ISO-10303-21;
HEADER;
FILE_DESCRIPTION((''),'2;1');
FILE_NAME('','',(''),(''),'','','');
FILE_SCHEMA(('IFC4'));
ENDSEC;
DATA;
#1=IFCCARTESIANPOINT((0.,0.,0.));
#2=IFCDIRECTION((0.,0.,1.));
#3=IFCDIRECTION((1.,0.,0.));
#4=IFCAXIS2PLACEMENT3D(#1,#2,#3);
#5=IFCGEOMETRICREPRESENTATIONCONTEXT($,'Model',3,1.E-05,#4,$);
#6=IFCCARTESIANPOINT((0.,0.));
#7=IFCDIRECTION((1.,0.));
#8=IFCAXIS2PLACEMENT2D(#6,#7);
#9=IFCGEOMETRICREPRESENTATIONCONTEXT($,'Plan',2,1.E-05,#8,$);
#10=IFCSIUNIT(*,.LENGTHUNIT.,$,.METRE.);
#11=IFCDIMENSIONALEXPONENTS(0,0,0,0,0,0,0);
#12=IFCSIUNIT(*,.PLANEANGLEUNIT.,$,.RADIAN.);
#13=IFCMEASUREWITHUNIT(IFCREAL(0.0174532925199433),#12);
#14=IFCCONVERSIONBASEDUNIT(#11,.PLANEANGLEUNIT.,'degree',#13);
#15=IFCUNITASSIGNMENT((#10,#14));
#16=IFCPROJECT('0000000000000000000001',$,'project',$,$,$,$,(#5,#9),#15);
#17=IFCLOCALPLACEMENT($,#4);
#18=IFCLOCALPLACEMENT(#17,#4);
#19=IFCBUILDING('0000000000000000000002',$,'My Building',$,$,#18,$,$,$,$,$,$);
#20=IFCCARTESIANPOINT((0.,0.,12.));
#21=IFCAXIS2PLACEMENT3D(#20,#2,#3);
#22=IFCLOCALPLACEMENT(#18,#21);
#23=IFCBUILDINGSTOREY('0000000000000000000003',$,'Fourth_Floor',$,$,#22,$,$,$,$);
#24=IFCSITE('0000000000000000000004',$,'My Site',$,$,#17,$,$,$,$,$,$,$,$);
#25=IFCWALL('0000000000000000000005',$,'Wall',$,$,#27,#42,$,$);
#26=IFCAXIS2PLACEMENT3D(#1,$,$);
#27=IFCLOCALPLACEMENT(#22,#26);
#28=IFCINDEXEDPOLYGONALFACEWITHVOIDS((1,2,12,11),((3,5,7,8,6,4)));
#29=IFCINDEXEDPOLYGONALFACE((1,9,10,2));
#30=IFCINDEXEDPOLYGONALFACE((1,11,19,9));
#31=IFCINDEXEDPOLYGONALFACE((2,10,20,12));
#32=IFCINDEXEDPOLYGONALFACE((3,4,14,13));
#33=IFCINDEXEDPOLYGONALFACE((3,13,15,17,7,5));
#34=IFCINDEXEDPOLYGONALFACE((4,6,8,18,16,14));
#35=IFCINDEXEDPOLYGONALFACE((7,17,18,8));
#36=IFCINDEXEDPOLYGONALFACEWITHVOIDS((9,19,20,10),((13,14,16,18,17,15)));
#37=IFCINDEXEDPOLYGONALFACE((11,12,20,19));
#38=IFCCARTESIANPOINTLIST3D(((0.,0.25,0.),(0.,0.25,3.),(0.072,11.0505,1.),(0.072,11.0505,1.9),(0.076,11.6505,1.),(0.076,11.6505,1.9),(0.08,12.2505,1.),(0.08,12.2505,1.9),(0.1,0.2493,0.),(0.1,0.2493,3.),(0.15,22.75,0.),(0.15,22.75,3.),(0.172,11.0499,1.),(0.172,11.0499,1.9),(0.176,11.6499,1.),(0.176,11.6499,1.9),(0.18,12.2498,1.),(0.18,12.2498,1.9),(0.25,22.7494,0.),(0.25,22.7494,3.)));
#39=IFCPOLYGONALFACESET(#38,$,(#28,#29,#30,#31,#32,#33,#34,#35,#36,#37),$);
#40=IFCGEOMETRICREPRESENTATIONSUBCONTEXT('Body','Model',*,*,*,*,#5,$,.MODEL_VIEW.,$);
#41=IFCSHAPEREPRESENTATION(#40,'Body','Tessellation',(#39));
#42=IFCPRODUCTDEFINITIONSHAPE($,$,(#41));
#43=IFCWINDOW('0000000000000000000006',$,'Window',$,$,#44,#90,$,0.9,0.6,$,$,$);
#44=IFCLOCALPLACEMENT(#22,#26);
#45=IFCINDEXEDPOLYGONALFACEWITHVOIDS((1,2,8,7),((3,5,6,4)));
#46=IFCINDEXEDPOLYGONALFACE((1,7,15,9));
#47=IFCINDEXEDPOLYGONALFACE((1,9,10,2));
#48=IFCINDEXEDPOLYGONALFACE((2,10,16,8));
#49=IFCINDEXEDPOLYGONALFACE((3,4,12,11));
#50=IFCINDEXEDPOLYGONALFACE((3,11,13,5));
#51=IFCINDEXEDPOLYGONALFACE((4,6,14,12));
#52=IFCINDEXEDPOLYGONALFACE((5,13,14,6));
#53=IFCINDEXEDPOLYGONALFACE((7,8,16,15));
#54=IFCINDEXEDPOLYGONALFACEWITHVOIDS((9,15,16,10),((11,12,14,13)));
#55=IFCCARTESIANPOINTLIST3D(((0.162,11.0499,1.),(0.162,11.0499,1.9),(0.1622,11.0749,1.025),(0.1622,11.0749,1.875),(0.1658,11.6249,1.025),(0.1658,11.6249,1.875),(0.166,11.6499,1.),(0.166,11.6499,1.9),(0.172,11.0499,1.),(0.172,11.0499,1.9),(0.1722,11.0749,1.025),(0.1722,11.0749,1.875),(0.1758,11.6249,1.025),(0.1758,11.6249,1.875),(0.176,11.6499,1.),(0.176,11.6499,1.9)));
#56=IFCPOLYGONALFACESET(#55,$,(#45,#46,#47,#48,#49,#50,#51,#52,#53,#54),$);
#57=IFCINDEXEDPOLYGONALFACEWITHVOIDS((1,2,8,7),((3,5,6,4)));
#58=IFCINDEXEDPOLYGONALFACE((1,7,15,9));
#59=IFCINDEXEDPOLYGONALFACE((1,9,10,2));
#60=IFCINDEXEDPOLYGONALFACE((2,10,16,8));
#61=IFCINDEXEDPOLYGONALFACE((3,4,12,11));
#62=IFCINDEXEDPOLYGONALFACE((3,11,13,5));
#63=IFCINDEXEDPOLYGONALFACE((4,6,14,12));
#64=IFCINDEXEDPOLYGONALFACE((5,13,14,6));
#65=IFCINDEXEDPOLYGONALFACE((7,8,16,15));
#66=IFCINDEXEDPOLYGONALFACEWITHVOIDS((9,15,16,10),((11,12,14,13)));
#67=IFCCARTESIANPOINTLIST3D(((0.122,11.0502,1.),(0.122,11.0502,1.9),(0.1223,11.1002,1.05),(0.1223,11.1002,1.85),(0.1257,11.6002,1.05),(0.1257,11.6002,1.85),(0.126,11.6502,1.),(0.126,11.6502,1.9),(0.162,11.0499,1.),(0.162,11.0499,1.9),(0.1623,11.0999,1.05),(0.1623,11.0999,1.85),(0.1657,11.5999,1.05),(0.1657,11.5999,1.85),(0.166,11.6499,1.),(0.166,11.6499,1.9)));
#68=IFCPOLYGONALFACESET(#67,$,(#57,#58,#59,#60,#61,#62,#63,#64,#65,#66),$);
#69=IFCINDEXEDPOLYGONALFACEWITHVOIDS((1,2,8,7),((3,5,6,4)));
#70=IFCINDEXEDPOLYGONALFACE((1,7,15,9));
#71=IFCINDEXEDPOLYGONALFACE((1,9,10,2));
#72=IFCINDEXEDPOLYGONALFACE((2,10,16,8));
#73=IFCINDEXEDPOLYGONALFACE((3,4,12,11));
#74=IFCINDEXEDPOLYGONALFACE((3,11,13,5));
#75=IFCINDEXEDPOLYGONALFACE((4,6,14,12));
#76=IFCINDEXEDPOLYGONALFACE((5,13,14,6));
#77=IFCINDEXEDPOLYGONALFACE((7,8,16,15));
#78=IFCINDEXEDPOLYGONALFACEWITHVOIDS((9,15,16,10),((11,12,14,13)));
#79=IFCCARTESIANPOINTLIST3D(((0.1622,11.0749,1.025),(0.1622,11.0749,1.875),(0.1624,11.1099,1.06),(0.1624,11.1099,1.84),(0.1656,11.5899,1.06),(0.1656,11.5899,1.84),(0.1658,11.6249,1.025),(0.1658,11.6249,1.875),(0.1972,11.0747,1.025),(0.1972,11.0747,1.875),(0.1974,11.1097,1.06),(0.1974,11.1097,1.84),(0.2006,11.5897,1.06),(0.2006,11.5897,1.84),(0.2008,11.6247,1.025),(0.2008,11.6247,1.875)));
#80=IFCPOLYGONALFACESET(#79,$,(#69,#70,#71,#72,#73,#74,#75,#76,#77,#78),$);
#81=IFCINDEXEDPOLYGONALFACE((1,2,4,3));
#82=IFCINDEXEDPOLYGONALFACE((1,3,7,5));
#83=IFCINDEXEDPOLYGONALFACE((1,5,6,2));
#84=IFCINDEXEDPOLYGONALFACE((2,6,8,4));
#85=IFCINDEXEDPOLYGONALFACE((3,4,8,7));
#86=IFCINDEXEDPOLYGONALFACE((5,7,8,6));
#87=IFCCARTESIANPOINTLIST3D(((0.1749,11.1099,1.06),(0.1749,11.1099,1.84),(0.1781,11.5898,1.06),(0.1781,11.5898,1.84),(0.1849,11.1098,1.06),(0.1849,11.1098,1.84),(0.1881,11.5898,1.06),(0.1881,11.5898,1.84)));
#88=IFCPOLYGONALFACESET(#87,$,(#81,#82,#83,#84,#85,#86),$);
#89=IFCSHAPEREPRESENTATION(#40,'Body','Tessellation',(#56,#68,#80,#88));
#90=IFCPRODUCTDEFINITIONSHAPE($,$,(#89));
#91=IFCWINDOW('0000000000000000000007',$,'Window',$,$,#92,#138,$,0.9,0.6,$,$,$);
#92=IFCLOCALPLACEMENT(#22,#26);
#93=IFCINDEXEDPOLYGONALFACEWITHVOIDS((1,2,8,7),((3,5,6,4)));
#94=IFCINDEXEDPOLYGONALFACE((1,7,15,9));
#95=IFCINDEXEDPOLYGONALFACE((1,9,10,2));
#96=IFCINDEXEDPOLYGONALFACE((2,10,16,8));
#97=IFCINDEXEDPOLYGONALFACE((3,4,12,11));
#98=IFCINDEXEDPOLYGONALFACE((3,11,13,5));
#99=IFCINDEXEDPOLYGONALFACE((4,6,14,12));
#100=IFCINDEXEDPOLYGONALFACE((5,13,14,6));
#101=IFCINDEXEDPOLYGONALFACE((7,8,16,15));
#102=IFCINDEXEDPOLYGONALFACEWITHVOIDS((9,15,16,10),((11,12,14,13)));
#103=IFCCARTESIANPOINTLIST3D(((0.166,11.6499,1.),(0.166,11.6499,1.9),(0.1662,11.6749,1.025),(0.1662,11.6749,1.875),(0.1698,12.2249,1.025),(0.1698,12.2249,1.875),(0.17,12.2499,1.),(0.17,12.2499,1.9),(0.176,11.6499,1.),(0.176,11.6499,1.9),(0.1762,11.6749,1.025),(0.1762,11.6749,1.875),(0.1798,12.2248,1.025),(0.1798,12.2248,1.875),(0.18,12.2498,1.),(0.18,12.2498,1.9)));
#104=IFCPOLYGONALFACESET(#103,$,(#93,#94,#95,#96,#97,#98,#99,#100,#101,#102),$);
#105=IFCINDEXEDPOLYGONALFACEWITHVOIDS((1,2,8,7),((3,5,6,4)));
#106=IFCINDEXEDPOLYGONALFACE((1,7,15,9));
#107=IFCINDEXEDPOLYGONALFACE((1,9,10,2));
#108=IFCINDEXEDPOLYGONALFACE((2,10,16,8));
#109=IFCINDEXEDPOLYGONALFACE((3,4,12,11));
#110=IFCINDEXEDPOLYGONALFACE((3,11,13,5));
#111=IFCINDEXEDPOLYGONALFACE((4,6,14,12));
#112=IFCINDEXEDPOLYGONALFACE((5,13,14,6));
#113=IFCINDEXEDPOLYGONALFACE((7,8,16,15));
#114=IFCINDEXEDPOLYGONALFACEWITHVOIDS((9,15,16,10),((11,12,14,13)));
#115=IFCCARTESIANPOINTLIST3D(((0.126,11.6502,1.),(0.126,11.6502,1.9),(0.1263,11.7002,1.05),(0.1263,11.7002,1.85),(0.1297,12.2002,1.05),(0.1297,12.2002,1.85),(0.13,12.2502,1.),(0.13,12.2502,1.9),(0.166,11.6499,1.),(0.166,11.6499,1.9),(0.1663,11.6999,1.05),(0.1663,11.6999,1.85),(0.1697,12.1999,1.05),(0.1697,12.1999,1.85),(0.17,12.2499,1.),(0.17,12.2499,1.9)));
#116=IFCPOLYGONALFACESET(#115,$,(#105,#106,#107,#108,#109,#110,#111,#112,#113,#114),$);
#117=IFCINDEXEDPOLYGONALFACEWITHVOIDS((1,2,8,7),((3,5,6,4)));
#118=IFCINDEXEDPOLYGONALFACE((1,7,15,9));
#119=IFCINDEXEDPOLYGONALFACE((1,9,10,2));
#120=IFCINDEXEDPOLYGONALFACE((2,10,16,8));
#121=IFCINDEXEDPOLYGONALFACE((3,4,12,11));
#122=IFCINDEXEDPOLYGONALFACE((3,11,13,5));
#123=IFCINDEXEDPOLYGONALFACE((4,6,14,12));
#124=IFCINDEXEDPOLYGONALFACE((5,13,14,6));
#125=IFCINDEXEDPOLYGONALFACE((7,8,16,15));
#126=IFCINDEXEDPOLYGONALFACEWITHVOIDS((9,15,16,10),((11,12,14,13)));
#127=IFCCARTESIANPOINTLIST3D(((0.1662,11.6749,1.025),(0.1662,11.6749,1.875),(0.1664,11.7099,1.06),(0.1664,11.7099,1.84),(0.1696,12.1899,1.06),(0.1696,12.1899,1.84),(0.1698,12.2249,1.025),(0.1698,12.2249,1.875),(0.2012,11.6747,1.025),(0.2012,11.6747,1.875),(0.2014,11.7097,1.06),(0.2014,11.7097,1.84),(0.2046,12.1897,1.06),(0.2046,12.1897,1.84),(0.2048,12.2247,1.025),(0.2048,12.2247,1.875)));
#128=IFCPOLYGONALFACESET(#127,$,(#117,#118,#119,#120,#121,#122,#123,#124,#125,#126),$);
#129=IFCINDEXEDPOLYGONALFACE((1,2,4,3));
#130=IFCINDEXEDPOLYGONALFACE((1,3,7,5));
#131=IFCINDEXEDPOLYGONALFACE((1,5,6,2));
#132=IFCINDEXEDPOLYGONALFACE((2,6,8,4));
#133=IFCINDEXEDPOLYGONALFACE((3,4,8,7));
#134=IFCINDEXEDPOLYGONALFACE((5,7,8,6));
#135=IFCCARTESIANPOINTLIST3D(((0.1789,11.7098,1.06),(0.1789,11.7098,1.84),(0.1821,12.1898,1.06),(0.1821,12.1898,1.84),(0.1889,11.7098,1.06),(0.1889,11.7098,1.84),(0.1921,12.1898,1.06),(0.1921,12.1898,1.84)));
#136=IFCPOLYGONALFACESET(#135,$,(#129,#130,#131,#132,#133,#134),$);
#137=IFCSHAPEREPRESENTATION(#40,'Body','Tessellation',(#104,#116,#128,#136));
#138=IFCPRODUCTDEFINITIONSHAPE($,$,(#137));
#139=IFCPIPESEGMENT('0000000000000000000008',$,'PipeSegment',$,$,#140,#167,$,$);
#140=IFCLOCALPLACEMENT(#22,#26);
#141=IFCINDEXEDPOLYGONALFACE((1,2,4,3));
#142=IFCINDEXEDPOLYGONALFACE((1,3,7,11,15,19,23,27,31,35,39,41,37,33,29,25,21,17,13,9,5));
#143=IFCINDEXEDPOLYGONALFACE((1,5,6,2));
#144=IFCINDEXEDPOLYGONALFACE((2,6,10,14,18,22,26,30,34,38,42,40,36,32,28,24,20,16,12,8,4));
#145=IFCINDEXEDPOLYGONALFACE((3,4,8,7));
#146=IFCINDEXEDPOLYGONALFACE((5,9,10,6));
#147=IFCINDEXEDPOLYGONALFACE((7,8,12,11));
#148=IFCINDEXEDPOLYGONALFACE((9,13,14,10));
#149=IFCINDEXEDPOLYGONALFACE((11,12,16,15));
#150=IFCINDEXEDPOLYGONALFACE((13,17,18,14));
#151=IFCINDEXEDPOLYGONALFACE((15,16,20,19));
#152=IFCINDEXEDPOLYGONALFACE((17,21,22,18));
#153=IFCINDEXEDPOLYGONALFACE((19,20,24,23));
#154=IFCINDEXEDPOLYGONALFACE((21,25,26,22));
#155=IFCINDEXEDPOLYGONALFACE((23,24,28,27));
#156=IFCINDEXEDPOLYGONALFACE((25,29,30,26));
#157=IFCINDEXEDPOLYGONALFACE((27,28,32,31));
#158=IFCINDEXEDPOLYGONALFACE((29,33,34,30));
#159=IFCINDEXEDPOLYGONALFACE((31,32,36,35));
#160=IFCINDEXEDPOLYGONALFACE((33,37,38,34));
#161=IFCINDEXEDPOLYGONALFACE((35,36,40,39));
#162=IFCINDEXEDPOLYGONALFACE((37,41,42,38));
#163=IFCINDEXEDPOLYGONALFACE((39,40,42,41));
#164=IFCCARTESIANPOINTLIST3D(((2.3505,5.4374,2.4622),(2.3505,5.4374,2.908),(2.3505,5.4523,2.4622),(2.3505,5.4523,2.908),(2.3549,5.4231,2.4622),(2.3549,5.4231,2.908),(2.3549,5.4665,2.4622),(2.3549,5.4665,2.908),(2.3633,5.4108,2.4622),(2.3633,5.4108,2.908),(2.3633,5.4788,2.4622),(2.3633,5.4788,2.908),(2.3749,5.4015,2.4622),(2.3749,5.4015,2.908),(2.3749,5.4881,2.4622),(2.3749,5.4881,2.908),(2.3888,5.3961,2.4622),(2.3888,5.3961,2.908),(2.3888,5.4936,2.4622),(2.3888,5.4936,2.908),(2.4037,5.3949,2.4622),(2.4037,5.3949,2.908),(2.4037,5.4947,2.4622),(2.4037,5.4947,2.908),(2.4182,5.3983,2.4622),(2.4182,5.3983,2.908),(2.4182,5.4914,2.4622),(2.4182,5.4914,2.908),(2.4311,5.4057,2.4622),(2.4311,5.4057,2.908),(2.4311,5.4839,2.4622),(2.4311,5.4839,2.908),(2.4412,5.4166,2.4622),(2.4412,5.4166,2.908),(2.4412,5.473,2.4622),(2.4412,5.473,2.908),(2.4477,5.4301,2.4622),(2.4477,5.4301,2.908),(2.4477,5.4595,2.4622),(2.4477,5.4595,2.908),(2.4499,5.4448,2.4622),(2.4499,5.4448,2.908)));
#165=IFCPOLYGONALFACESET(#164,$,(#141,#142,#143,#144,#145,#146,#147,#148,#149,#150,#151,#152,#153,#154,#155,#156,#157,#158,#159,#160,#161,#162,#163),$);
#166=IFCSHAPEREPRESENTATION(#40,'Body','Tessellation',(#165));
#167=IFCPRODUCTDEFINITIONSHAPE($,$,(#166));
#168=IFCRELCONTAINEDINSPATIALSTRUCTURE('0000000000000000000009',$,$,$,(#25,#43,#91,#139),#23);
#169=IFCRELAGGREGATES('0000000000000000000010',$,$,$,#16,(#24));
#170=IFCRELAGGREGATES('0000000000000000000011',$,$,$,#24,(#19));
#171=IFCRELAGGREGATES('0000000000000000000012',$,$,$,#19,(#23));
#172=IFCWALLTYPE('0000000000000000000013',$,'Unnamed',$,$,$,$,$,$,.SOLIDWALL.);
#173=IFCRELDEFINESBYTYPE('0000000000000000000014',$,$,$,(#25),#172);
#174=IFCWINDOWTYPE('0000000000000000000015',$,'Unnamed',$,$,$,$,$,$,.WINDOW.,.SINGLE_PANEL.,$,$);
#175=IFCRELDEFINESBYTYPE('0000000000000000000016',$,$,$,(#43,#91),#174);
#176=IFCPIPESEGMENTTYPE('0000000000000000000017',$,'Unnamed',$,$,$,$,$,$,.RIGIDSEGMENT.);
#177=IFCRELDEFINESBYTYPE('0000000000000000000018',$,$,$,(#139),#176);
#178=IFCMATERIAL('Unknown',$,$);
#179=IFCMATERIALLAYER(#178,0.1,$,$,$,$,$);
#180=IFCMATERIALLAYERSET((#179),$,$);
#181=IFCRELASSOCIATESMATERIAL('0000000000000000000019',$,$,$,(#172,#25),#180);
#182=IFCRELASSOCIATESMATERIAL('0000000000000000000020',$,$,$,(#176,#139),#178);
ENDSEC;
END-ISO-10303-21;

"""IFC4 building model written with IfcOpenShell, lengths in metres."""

from ifc_helpers import new_model, entity, si_unit, converted_unit, frame, origin_with_axes, origin_2d_with_axis, place, context, subcontext, project, spatial, line, indexed_curve, circle, outline, extrude, shape, source, transform, mapped, material, layer, layer_set, layer_usage, material_profile, profile_set, profile_usage, type_object, type_shapes, element, fill, save


model = new_model("IFC4")

# Units and contexts
model_context = context("Model", 3, precision=1e-05, world=origin_with_axes())
plan_context = context("Plan", 2, precision=1e-05, world=origin_2d_with_axis())
body_context_1 = subcontext(model_context, "Body", "Model", "MODEL_VIEW")
body_context_2 = subcontext(plan_context, "Body", "Plan", "PLAN_VIEW")
ifc_project = project(units=[si_unit("LENGTHUNIT", "METRE"), converted_unit("PLANEANGLEUNIT", "degree", entity("IfcReal", 0.0174532925199433), si_unit("PLANEANGLEUNIT", "RADIAN"), dimensions=[0, 0, 0, 0, 0, 0, 0])], contexts=[model_context, plan_context])

# Site, building, storey
site_placement = place(None, origin_with_axes())
site = spatial("IfcSite", under=ifc_project, at=site_placement, Name="My Site")
building_placement = place(site_placement, origin_with_axes())
building = spatial("IfcBuilding", under=site, at=building_placement, Name="My Building")
storey_placement = place(building_placement, frame((0.0, 0.0, 12.0), z_axis=(0.0, 0.0, 1.0), x_axis=(1.0, 0.0, 0.0)))
storey = spatial("IfcBuildingStorey", under=building, at=storey_placement, Name="Fourth_Floor")

# Shared definitions
ifc_material = material(Name="Unknown")

# Shared definitions
ifc_layer = layer(ifc_material, 0.1)
ifc_layer_set = layer_set([ifc_layer])
wall_type = type_object("IfcWallType", Name="Unnamed", PredefinedType="SOLIDWALL", material=ifc_layer_set)

# Wall, openings, windows
ifc_layer_usage_1 = layer_usage(ifc_layer_set, "AXIS2", "POSITIVE", 0.0)
wall_1_placement = place(storey_placement, frame((0.15, 22.75, 0.0), z_axis=(0.0, 0.0, 1.0), x_axis=(-0.006667, -0.999978, 0.0)))
wall_1 = element("IfcWall", 1, at=wall_1_placement, inside=storey, type_object=wall_type, material=ifc_layer_usage_1, Name="Wall", context=body_context_1, shape_type="SweptSolid", body=[
    extrude(outline(indexed_curve([(0.0, 0.0), (0.0, 0.1), (22.5005, 0.1), (22.5005, 0.0)], segments=[line(1, 2, 3, 4, 1)])), origin_with_axes(), (0.0, 0.0, 1.0), 3.0),
])
shared_shape_1 = source(origin_with_axes(), body_context_1, "Body", "SweptSolid", [
    extrude(outline(indexed_curve([(0.0, 0.0), (0.6, 0.0), (0.6, 0.9), (0.0, 0.9)], segments=[line(1, 2, 3, 4, 1)])), frame((0.0, -0.6, 0.0), z_axis=(0.0, -1.0, 0.0), x_axis=(1.0, 0.0, 0.0)), (0.0, 0.0, -1.0), 1.2),
])
opening_1_placement = place(wall_1_placement, frame((11.0997, 0.0, 1.0), z_axis=(0.0, 0.0, 1.0), x_axis=(1.0, 0.0, 0.0)))
opening_1 = element("IfcOpeningElement", 2, at=opening_1_placement, cuts=wall_1, PredefinedType="OPENING", context=body_context_1, shape_type="MappedRepresentation", body=[
    mapped(shared_shape_1, transform((0.0, 0.0, 0.0), x_axis=(1.0, 0.0, 0.0), y_axis=(0.0, 1.0, 0.0), z_axis=(0.0, 0.0, 1.0), scale=1.0)),
])
opening_2_placement = place(wall_1_placement, frame((10.4997, 0.0, 1.0), z_axis=(0.0, 0.0, 1.0), x_axis=(1.0, 0.0, 0.0)))
opening_2 = element("IfcOpeningElement", 3, at=opening_2_placement, cuts=wall_1, PredefinedType="OPENING", context=body_context_1, shape_type="MappedRepresentation", body=[
    mapped(shared_shape_1, transform((0.0, 0.0, 0.0), x_axis=(1.0, 0.0, 0.0), y_axis=(0.0, 1.0, 0.0), z_axis=(0.0, 0.0, 1.0), scale=1.0)),
])
window_type = type_object("IfcWindowType", Name="Unnamed", PartitioningType="SINGLE_PANEL", PredefinedType="WINDOW")
shared_shape_2 = source(origin_with_axes(), body_context_1, "Body", "SweptSolid", [
    extrude(outline(indexed_curve([(0.0, 0.0), (0.6, 0.0), (0.6, 0.9), (0.0, 0.9)], segments=[line(1, 2, 3, 4, 1)]), holes=[indexed_curve([(0.025, 0.025), (0.575, 0.025), (0.575, 0.875), (0.025, 0.875)], segments=[line(1, 2, 3, 4, 1)])]), frame((0.0, 0.09, 0.0), z_axis=(0.0, -1.0, 0.0), x_axis=(1.0, 0.0, 0.0)), (0.0, 0.0, -1.0), 0.01),
    extrude(outline(indexed_curve([(0.0, 0.0), (0.6, 0.0), (0.6, 0.9), (0.0, 0.9)], segments=[line(1, 2, 3, 4, 1)]), holes=[indexed_curve([(0.05, 0.05), (0.55, 0.05), (0.55, 0.85), (0.05, 0.85)], segments=[line(1, 2, 3, 4, 1)])]), frame((0.0, 0.05, 0.0), z_axis=(0.0, -1.0, 0.0), x_axis=(1.0, 0.0, 0.0)), (0.0, 0.0, -1.0), 0.04),
    extrude(outline(indexed_curve([(0.0, 0.0), (0.55, 0.0), (0.55, 0.85), (0.0, 0.85)], segments=[line(1, 2, 3, 4, 1)]), holes=[indexed_curve([(0.035, 0.035), (0.515, 0.035), (0.515, 0.815), (0.035, 0.815)], segments=[line(1, 2, 3, 4, 1)])]), frame((0.025, 0.09, 0.025), z_axis=(0.0, -1.0, 0.0), x_axis=(1.0, 0.0, 0.0)), (0.0, 0.0, -1.0), 0.035),
    extrude(outline(indexed_curve([(0.035, 0.035), (0.515, 0.035), (0.515, 0.815), (0.035, 0.815)], segments=[line(1, 2, 3, 4, 1)])), frame((0.025, 0.1025, 0.025), z_axis=(0.0, -1.0, 0.0), x_axis=(1.0, 0.0, 0.0)), (0.0, 0.0, -1.0), 0.01),
])
shared_shape_3 = source(origin_with_axes(), body_context_2, "Body", "Curve2D", [
    entity("IfcIndexedPolyCurve", entity("IfcCartesianPointList2D", [[0.05, 0.05], [0.55, 0.05]])),
    entity("IfcIndexedPolyCurve", entity("IfcCartesianPointList2D", [[0.0, 0.1], [0.025, 0.1], [0.025, 0.09], [0.05, 0.09], [0.05, 0.05], [0.0, 0.05]]), [entity("IfcLineIndex", [1, 2, 3, 4, 5, 6, 1])]),
    entity("IfcIndexedPolyCurve", entity("IfcCartesianPointList2D", [[0.6, 0.1], [0.575, 0.1], [0.575, 0.09], [0.55, 0.09], [0.55, 0.05], [0.6, 0.05]]), [entity("IfcLineIndex", [1, 2, 3, 4, 5, 6, 1])]),
    entity("IfcIndexedPolyCurve", entity("IfcCartesianPointList2D", [[0.025, 0.09], [0.06, 0.09], [0.06, 0.125], [0.025, 0.125]]), [entity("IfcLineIndex", [1, 2, 3, 4, 1])]),
    entity("IfcIndexedPolyCurve", entity("IfcCartesianPointList2D", [[0.575, 0.09], [0.54, 0.09], [0.54, 0.125], [0.575, 0.125]]), [entity("IfcLineIndex", [1, 2, 3, 4, 1])]),
    entity("IfcIndexedPolyCurve", entity("IfcCartesianPointList2D", [[0.06, 0.09], [0.54, 0.09]])),
    entity("IfcIndexedPolyCurve", entity("IfcCartesianPointList2D", [[0.06, 0.125], [0.54, 0.125]])),
    entity("IfcIndexedPolyCurve", entity("IfcCartesianPointList2D", [[0.06, 0.1075], [0.54, 0.1075]])),
])
type_shapes(window_type, [shared_shape_2, shared_shape_3])
window_1_placement = place(opening_1_placement, frame((0.0, 0.0, 0.0), z_axis=(0.0, 0.0, 1.0), x_axis=(1.0, 0.0, 0.0)))
window_1 = element("IfcWindow", 4, at=window_1_placement, inside=storey, type_object=window_type, Name="Window", OverallHeight=0.9, OverallWidth=0.6, shapes=[
    shape(body_context_1, "Body", "MappedRepresentation", [mapped(shared_shape_2, transform((0.0, 0.0, 0.0), x_axis=(1.0, 0.0, 0.0), y_axis=(0.0, 1.0, 0.0), z_axis=(0.0, 0.0, 1.0), scale=1.0))]),
    shape(body_context_2, "Body", "MappedRepresentation", [mapped(shared_shape_3, transform((0.0, 0.0, 0.0), x_axis=(1.0, 0.0, 0.0), y_axis=(0.0, 1.0, 0.0), z_axis=(0.0, 0.0, 1.0), scale=1.0))]),
])
fill(opening_1, window_1)
window_2_placement = place(opening_2_placement, frame((0.0, 0.0, 0.0), z_axis=(0.0, 0.0, 1.0), x_axis=(1.0, 0.0, 0.0)))
window_2 = element("IfcWindow", 5, at=window_2_placement, inside=storey, type_object=window_type, Name="Window", OverallHeight=0.9, OverallWidth=0.6, shapes=[
    shape(body_context_1, "Body", "MappedRepresentation", [mapped(shared_shape_2, transform((0.0, 0.0, 0.0), x_axis=(1.0, 0.0, 0.0), y_axis=(0.0, 1.0, 0.0), z_axis=(0.0, 0.0, 1.0), scale=1.0))]),
    shape(body_context_2, "Body", "MappedRepresentation", [mapped(shared_shape_3, transform((0.0, 0.0, 0.0), x_axis=(1.0, 0.0, 0.0), y_axis=(0.0, 1.0, 0.0), z_axis=(0.0, 0.0, 1.0), scale=1.0))]),
])
fill(opening_2, window_2)

# Pipe segment
ifc_material_profile_1 = material_profile(ifc_material, circle(Radius=0.05))
ifc_profile_set_1 = profile_set([ifc_material_profile_1])
ifc_profile_usage_1 = profile_usage(ifc_profile_set_1, cardinal=5)
pipe_segment_type = type_object("IfcPipeSegmentType", Name="Unnamed", PredefinedType="RIGIDSEGMENT", material=ifc_profile_set_1)
pipe_segment_1_placement = place(storey_placement, frame((2.3999, 5.4448, 2.908), z_axis=(0.0, 0.0, -1.0), x_axis=(1.0, 0.0, 0.0)))
element("IfcPipeSegment", 6, at=pipe_segment_1_placement, inside=storey, type_object=pipe_segment_type, material=ifc_profile_usage_1, Name="PipeSegment", context=body_context_1, shape_type="SweptSolid", body=[
    extrude(circle(Radius=0.05), origin_with_axes(), (0.0, 0.0, 1.0), 0.4458),
])

save(model, "model.ifc")
